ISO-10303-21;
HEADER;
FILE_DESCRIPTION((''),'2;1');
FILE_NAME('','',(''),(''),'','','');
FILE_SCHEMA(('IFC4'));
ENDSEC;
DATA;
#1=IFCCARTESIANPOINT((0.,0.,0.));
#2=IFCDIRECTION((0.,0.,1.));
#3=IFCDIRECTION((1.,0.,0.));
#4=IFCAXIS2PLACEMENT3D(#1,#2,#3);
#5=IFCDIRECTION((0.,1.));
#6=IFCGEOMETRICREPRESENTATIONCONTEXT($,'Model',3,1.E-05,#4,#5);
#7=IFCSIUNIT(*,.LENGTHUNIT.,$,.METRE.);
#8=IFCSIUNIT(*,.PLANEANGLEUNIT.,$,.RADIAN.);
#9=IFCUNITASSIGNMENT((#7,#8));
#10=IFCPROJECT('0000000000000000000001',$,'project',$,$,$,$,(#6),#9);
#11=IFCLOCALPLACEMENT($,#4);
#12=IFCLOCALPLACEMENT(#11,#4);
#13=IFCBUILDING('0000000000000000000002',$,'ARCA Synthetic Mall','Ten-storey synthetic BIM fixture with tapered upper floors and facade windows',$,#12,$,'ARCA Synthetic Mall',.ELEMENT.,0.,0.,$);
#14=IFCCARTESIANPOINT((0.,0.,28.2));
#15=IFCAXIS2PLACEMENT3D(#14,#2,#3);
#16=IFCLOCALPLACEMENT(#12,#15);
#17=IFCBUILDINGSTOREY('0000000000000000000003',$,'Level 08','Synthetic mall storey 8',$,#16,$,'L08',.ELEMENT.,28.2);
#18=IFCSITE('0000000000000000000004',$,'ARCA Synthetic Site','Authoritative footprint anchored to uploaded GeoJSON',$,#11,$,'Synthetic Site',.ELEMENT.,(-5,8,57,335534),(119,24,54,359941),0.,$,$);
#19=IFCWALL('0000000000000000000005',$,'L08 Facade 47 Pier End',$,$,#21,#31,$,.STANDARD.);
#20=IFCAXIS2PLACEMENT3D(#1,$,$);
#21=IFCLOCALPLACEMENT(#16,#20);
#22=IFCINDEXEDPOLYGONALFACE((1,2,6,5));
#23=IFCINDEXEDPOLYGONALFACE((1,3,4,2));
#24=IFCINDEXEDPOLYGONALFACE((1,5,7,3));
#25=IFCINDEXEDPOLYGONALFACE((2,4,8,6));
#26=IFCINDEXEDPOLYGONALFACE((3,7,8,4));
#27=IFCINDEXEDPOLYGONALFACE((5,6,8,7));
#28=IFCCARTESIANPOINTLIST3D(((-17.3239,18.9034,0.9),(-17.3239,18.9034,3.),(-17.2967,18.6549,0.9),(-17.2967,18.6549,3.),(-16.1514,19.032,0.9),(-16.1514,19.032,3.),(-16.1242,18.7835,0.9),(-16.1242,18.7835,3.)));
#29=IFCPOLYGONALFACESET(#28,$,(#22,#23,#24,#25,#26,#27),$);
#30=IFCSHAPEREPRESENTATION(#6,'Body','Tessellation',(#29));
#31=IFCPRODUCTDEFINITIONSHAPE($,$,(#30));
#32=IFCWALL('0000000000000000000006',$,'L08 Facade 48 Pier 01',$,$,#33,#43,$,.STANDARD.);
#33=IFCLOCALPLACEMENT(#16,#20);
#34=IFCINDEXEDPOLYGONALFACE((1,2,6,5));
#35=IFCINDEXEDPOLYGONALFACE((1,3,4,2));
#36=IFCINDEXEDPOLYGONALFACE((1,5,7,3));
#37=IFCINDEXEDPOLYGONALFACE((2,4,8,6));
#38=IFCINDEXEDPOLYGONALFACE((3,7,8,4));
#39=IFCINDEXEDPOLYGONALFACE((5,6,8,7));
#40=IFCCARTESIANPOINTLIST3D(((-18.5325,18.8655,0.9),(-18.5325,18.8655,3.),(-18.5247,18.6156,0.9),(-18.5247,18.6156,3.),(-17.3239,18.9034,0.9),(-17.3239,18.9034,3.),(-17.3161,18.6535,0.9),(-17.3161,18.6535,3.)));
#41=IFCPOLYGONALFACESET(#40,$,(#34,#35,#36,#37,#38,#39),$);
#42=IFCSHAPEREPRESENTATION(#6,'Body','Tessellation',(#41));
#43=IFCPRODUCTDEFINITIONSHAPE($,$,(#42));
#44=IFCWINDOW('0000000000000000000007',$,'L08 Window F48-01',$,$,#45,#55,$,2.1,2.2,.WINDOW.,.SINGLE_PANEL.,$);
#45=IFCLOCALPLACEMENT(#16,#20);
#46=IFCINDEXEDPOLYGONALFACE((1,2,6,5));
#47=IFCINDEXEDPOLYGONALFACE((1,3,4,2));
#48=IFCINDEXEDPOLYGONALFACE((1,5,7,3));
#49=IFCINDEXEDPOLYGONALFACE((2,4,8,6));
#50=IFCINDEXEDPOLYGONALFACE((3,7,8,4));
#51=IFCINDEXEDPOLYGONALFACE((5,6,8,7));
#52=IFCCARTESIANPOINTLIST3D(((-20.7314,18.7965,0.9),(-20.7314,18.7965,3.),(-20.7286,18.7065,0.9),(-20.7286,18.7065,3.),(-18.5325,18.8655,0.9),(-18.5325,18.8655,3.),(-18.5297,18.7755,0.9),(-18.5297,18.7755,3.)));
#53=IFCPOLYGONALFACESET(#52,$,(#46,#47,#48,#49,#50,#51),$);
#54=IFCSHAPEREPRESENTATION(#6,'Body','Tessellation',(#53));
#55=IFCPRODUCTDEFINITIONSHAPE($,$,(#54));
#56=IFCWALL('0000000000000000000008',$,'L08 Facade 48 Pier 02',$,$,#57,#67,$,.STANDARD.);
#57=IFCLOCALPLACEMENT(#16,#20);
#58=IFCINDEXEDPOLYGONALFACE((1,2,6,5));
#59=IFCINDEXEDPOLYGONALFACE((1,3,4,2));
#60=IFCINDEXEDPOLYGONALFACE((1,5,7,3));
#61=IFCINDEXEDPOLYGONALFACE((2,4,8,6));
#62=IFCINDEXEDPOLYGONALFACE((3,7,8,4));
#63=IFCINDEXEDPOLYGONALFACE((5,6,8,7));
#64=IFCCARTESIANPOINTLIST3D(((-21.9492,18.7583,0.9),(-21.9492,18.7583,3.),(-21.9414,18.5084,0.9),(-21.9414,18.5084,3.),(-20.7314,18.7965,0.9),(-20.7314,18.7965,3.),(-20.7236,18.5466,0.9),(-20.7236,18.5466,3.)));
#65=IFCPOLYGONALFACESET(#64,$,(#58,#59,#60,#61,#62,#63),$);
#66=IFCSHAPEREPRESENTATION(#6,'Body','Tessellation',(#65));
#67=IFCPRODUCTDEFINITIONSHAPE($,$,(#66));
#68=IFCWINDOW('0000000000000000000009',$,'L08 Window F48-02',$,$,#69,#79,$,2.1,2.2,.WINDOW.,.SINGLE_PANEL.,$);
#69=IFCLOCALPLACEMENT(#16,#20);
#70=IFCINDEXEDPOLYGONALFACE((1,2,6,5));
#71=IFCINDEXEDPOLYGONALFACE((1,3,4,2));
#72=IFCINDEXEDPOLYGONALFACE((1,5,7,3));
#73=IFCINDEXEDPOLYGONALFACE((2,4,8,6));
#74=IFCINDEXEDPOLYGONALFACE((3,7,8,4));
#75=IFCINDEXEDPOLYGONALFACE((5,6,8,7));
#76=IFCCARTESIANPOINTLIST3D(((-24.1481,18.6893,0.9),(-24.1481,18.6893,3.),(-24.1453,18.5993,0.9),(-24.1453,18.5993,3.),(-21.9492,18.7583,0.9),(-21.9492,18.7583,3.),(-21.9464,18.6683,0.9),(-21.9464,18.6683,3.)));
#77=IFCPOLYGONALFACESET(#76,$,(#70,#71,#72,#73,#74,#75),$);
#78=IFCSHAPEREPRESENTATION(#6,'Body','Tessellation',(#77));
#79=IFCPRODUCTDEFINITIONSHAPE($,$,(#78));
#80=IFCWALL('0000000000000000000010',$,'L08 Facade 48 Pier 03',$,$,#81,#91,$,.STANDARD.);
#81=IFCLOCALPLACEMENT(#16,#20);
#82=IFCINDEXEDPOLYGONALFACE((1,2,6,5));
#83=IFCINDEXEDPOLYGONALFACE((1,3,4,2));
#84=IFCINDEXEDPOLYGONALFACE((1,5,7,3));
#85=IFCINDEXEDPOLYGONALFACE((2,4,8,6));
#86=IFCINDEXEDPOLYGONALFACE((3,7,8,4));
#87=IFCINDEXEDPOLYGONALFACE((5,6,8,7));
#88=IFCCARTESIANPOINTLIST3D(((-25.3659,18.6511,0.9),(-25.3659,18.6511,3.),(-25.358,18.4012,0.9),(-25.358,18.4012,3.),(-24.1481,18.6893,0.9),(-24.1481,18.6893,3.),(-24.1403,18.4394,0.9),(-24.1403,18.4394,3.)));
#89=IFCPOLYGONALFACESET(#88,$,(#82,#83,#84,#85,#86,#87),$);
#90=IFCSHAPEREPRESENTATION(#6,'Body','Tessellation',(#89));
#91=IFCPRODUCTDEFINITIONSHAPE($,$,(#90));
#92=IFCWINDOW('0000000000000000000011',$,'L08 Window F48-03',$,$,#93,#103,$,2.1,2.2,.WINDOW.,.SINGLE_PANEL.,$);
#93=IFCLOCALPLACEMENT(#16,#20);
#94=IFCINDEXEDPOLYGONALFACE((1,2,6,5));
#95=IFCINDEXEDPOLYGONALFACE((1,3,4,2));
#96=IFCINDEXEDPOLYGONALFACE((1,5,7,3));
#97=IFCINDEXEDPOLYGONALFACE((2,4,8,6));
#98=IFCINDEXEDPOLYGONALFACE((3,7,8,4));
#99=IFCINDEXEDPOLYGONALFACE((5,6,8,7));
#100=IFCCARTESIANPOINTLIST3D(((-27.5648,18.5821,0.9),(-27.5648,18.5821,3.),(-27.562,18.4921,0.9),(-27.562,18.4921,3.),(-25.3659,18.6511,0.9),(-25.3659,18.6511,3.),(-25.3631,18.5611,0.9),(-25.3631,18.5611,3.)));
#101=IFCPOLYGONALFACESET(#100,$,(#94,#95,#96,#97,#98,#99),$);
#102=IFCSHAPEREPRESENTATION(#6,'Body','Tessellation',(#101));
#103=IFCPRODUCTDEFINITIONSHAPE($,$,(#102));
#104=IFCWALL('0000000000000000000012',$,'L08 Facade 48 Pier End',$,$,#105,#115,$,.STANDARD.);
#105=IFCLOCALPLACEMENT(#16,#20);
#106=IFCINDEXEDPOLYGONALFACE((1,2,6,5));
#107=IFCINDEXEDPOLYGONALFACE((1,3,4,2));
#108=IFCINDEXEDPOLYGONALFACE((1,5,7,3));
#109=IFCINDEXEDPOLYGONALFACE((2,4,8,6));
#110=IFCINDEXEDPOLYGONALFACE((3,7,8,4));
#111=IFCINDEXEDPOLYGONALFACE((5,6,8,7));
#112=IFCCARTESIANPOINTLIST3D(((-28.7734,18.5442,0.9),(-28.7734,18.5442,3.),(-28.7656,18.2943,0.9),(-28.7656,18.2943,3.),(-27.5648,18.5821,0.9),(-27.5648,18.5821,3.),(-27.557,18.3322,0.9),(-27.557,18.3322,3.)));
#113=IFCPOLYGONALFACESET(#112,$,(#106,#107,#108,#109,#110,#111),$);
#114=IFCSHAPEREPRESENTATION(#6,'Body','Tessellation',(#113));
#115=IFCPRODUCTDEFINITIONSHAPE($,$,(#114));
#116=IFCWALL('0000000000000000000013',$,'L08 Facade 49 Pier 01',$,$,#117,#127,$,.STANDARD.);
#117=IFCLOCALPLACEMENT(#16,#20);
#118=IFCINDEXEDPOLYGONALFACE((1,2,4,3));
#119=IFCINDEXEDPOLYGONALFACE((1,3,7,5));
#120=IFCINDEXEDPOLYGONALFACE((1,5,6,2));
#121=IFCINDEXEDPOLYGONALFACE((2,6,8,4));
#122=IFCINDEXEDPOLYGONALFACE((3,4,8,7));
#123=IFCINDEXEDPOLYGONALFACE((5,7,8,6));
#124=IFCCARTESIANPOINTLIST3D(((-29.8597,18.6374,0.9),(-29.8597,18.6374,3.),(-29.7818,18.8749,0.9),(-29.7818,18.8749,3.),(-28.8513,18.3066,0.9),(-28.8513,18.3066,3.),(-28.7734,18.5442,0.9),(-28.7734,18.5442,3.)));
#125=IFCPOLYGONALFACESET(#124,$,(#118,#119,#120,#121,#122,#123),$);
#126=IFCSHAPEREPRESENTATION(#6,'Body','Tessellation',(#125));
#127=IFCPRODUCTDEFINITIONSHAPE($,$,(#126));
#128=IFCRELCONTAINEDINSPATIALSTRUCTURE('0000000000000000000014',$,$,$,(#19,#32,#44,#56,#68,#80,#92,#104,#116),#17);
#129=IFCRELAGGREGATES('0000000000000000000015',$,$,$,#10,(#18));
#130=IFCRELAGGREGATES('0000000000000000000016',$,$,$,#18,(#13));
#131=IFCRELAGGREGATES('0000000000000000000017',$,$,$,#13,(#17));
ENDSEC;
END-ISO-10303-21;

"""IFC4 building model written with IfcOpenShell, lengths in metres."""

from ifc_helpers import new_model, si_unit, direction, frame, origin_with_axes, place, context, project, spatial, polyline, outline, extrude, element, save


model = new_model("IFC4")

# Units and contexts
model_context = context("Model", 3, precision=1e-05, world=origin_with_axes(), true_north=direction((0.0, 1.0)))
ifc_project = project(units=[si_unit("LENGTHUNIT", "METRE"), si_unit("PLANEANGLEUNIT", "RADIAN")], contexts=[model_context])

# Site, building, storey
site_placement = place(None, origin_with_axes())
site = spatial("IfcSite", under=ifc_project, at=site_placement, Name="ARCA Synthetic Site", Description="Authoritative footprint anchored to uploaded GeoJSON", LongName="Synthetic Site", CompositionType="ELEMENT", RefLatitude=(-5, 8, 57, 335534), RefLongitude=(119, 24, 54, 359941), RefElevation=0.0)
building_placement = place(site_placement, origin_with_axes())
building = spatial("IfcBuilding", under=site, at=building_placement, Name="ARCA Synthetic Mall", Description="Ten-storey synthetic BIM fixture with tapered upper floors and facade windows", LongName="ARCA Synthetic Mall", CompositionType="ELEMENT", ElevationOfRefHeight=0.0, ElevationOfTerrain=0.0)
storey_placement = place(building_placement, frame((0.0, 0.0, 28.2), z_axis=(0.0, 0.0, 1.0), x_axis=(1.0, 0.0, 0.0)))
storey = spatial("IfcBuildingStorey", under=building, at=storey_placement, Name="Level 08", Description="Synthetic mall storey 8", LongName="L08", CompositionType="ELEMENT", Elevation=28.2)

# Walls
wall_1_placement = place(storey_placement, frame((0.0, 0.0, 0.9), z_axis=(0.0, 0.0, 1.0), x_axis=(1.0, 0.0, 0.0)))
element("IfcWall", 1, at=wall_1_placement, inside=storey, Name="L08 Facade 47 Pier End", PredefinedType="STANDARD", context=model_context, shape_type="SweptSolid", body=[
    extrude(outline(polyline([(-16.1514, 19.032), (-17.3239, 18.9034), (-17.2967, 18.6549), (-16.1242, 18.7835), (-16.1514, 19.032)])), origin_with_axes(), (0.0, 0.0, 1.0), 2.1),
])
wall_2_placement = place(storey_placement, frame((0.0, 0.0, 0.9), z_axis=(0.0, 0.0, 1.0), x_axis=(1.0, 0.0, 0.0)))
element("IfcWall", 2, at=wall_2_placement, inside=storey, Name="L08 Facade 48 Pier 01", PredefinedType="STANDARD", context=model_context, shape_type="SweptSolid", body=[
    extrude(outline(polyline([(-17.3239, 18.9034), (-18.5325, 18.8655), (-18.5247, 18.6156), (-17.3161, 18.6535), (-17.3239, 18.9034)])), origin_with_axes(), (0.0, 0.0, 1.0), 2.1),
])

# Window
window_1_placement = place(storey_placement, frame((0.0, 0.0, 0.9), z_axis=(0.0, 0.0, 1.0), x_axis=(1.0, 0.0, 0.0)))
element("IfcWindow", 3, at=window_1_placement, inside=storey, Name="L08 Window F48-01", OverallHeight=2.1, OverallWidth=2.2, PartitioningType="SINGLE_PANEL", PredefinedType="WINDOW", context=model_context, shape_type="SweptSolid", body=[
    extrude(outline(polyline([(-18.5325, 18.8655), (-20.7314, 18.7965), (-20.7286, 18.7065), (-18.5297, 18.7755), (-18.5325, 18.8655)])), origin_with_axes(), (0.0, 0.0, 1.0), 2.1),
])

# Wall
wall_3_placement = place(storey_placement, frame((0.0, 0.0, 0.9), z_axis=(0.0, 0.0, 1.0), x_axis=(1.0, 0.0, 0.0)))
element("IfcWall", 4, at=wall_3_placement, inside=storey, Name="L08 Facade 48 Pier 02", PredefinedType="STANDARD", context=model_context, shape_type="SweptSolid", body=[
    extrude(outline(polyline([(-20.7314, 18.7965), (-21.9492, 18.7583), (-21.9414, 18.5084), (-20.7236, 18.5466), (-20.7314, 18.7965)])), origin_with_axes(), (0.0, 0.0, 1.0), 2.1),
])

# Window
window_2_placement = place(storey_placement, frame((0.0, 0.0, 0.9), z_axis=(0.0, 0.0, 1.0), x_axis=(1.0, 0.0, 0.0)))
element("IfcWindow", 5, at=window_2_placement, inside=storey, Name="L08 Window F48-02", OverallHeight=2.1, OverallWidth=2.2, PartitioningType="SINGLE_PANEL", PredefinedType="WINDOW", context=model_context, shape_type="SweptSolid", body=[
    extrude(outline(polyline([(-21.9492, 18.7583), (-24.1481, 18.6893), (-24.1453, 18.5993), (-21.9464, 18.6683), (-21.9492, 18.7583)])), origin_with_axes(), (0.0, 0.0, 1.0), 2.1),
])

# Wall
wall_4_placement = place(storey_placement, frame((0.0, 0.0, 0.9), z_axis=(0.0, 0.0, 1.0), x_axis=(1.0, 0.0, 0.0)))
element("IfcWall", 6, at=wall_4_placement, inside=storey, Name="L08 Facade 48 Pier 03", PredefinedType="STANDARD", context=model_context, shape_type="SweptSolid", body=[
    extrude(outline(polyline([(-24.1481, 18.6893), (-25.3659, 18.6511), (-25.358, 18.4012), (-24.1403, 18.4394), (-24.1481, 18.6893)])), origin_with_axes(), (0.0, 0.0, 1.0), 2.1),
])

# Window
window_3_placement = place(storey_placement, frame((0.0, 0.0, 0.9), z_axis=(0.0, 0.0, 1.0), x_axis=(1.0, 0.0, 0.0)))
element("IfcWindow", 7, at=window_3_placement, inside=storey, Name="L08 Window F48-03", OverallHeight=2.1, OverallWidth=2.2, PartitioningType="SINGLE_PANEL", PredefinedType="WINDOW", context=model_context, shape_type="SweptSolid", body=[
    extrude(outline(polyline([(-25.3659, 18.6511), (-27.5648, 18.5821), (-27.562, 18.4921), (-25.3631, 18.5611), (-25.3659, 18.6511)])), origin_with_axes(), (0.0, 0.0, 1.0), 2.1),
])

# Walls
wall_5_placement = place(storey_placement, frame((0.0, 0.0, 0.9), z_axis=(0.0, 0.0, 1.0), x_axis=(1.0, 0.0, 0.0)))
element("IfcWall", 8, at=wall_5_placement, inside=storey, Name="L08 Facade 48 Pier End", PredefinedType="STANDARD", context=model_context, shape_type="SweptSolid", body=[
    extrude(outline(polyline([(-27.5648, 18.5821), (-28.7734, 18.5442), (-28.7656, 18.2943), (-27.557, 18.3322), (-27.5648, 18.5821)])), origin_with_axes(), (0.0, 0.0, 1.0), 2.1),
])
wall_6_placement = place(storey_placement, frame((0.0, 0.0, 0.9), z_axis=(0.0, 0.0, 1.0), x_axis=(1.0, 0.0, 0.0)))
element("IfcWall", 9, at=wall_6_placement, inside=storey, Name="L08 Facade 49 Pier 01", PredefinedType="STANDARD", context=model_context, shape_type="SweptSolid", body=[
    extrude(outline(polyline([(-28.7734, 18.5442), (-29.7818, 18.8749), (-29.8597, 18.6374), (-28.8513, 18.3066), (-28.7734, 18.5442)])), origin_with_axes(), (0.0, 0.0, 1.0), 2.1),
])

save(model, "model.ifc")
